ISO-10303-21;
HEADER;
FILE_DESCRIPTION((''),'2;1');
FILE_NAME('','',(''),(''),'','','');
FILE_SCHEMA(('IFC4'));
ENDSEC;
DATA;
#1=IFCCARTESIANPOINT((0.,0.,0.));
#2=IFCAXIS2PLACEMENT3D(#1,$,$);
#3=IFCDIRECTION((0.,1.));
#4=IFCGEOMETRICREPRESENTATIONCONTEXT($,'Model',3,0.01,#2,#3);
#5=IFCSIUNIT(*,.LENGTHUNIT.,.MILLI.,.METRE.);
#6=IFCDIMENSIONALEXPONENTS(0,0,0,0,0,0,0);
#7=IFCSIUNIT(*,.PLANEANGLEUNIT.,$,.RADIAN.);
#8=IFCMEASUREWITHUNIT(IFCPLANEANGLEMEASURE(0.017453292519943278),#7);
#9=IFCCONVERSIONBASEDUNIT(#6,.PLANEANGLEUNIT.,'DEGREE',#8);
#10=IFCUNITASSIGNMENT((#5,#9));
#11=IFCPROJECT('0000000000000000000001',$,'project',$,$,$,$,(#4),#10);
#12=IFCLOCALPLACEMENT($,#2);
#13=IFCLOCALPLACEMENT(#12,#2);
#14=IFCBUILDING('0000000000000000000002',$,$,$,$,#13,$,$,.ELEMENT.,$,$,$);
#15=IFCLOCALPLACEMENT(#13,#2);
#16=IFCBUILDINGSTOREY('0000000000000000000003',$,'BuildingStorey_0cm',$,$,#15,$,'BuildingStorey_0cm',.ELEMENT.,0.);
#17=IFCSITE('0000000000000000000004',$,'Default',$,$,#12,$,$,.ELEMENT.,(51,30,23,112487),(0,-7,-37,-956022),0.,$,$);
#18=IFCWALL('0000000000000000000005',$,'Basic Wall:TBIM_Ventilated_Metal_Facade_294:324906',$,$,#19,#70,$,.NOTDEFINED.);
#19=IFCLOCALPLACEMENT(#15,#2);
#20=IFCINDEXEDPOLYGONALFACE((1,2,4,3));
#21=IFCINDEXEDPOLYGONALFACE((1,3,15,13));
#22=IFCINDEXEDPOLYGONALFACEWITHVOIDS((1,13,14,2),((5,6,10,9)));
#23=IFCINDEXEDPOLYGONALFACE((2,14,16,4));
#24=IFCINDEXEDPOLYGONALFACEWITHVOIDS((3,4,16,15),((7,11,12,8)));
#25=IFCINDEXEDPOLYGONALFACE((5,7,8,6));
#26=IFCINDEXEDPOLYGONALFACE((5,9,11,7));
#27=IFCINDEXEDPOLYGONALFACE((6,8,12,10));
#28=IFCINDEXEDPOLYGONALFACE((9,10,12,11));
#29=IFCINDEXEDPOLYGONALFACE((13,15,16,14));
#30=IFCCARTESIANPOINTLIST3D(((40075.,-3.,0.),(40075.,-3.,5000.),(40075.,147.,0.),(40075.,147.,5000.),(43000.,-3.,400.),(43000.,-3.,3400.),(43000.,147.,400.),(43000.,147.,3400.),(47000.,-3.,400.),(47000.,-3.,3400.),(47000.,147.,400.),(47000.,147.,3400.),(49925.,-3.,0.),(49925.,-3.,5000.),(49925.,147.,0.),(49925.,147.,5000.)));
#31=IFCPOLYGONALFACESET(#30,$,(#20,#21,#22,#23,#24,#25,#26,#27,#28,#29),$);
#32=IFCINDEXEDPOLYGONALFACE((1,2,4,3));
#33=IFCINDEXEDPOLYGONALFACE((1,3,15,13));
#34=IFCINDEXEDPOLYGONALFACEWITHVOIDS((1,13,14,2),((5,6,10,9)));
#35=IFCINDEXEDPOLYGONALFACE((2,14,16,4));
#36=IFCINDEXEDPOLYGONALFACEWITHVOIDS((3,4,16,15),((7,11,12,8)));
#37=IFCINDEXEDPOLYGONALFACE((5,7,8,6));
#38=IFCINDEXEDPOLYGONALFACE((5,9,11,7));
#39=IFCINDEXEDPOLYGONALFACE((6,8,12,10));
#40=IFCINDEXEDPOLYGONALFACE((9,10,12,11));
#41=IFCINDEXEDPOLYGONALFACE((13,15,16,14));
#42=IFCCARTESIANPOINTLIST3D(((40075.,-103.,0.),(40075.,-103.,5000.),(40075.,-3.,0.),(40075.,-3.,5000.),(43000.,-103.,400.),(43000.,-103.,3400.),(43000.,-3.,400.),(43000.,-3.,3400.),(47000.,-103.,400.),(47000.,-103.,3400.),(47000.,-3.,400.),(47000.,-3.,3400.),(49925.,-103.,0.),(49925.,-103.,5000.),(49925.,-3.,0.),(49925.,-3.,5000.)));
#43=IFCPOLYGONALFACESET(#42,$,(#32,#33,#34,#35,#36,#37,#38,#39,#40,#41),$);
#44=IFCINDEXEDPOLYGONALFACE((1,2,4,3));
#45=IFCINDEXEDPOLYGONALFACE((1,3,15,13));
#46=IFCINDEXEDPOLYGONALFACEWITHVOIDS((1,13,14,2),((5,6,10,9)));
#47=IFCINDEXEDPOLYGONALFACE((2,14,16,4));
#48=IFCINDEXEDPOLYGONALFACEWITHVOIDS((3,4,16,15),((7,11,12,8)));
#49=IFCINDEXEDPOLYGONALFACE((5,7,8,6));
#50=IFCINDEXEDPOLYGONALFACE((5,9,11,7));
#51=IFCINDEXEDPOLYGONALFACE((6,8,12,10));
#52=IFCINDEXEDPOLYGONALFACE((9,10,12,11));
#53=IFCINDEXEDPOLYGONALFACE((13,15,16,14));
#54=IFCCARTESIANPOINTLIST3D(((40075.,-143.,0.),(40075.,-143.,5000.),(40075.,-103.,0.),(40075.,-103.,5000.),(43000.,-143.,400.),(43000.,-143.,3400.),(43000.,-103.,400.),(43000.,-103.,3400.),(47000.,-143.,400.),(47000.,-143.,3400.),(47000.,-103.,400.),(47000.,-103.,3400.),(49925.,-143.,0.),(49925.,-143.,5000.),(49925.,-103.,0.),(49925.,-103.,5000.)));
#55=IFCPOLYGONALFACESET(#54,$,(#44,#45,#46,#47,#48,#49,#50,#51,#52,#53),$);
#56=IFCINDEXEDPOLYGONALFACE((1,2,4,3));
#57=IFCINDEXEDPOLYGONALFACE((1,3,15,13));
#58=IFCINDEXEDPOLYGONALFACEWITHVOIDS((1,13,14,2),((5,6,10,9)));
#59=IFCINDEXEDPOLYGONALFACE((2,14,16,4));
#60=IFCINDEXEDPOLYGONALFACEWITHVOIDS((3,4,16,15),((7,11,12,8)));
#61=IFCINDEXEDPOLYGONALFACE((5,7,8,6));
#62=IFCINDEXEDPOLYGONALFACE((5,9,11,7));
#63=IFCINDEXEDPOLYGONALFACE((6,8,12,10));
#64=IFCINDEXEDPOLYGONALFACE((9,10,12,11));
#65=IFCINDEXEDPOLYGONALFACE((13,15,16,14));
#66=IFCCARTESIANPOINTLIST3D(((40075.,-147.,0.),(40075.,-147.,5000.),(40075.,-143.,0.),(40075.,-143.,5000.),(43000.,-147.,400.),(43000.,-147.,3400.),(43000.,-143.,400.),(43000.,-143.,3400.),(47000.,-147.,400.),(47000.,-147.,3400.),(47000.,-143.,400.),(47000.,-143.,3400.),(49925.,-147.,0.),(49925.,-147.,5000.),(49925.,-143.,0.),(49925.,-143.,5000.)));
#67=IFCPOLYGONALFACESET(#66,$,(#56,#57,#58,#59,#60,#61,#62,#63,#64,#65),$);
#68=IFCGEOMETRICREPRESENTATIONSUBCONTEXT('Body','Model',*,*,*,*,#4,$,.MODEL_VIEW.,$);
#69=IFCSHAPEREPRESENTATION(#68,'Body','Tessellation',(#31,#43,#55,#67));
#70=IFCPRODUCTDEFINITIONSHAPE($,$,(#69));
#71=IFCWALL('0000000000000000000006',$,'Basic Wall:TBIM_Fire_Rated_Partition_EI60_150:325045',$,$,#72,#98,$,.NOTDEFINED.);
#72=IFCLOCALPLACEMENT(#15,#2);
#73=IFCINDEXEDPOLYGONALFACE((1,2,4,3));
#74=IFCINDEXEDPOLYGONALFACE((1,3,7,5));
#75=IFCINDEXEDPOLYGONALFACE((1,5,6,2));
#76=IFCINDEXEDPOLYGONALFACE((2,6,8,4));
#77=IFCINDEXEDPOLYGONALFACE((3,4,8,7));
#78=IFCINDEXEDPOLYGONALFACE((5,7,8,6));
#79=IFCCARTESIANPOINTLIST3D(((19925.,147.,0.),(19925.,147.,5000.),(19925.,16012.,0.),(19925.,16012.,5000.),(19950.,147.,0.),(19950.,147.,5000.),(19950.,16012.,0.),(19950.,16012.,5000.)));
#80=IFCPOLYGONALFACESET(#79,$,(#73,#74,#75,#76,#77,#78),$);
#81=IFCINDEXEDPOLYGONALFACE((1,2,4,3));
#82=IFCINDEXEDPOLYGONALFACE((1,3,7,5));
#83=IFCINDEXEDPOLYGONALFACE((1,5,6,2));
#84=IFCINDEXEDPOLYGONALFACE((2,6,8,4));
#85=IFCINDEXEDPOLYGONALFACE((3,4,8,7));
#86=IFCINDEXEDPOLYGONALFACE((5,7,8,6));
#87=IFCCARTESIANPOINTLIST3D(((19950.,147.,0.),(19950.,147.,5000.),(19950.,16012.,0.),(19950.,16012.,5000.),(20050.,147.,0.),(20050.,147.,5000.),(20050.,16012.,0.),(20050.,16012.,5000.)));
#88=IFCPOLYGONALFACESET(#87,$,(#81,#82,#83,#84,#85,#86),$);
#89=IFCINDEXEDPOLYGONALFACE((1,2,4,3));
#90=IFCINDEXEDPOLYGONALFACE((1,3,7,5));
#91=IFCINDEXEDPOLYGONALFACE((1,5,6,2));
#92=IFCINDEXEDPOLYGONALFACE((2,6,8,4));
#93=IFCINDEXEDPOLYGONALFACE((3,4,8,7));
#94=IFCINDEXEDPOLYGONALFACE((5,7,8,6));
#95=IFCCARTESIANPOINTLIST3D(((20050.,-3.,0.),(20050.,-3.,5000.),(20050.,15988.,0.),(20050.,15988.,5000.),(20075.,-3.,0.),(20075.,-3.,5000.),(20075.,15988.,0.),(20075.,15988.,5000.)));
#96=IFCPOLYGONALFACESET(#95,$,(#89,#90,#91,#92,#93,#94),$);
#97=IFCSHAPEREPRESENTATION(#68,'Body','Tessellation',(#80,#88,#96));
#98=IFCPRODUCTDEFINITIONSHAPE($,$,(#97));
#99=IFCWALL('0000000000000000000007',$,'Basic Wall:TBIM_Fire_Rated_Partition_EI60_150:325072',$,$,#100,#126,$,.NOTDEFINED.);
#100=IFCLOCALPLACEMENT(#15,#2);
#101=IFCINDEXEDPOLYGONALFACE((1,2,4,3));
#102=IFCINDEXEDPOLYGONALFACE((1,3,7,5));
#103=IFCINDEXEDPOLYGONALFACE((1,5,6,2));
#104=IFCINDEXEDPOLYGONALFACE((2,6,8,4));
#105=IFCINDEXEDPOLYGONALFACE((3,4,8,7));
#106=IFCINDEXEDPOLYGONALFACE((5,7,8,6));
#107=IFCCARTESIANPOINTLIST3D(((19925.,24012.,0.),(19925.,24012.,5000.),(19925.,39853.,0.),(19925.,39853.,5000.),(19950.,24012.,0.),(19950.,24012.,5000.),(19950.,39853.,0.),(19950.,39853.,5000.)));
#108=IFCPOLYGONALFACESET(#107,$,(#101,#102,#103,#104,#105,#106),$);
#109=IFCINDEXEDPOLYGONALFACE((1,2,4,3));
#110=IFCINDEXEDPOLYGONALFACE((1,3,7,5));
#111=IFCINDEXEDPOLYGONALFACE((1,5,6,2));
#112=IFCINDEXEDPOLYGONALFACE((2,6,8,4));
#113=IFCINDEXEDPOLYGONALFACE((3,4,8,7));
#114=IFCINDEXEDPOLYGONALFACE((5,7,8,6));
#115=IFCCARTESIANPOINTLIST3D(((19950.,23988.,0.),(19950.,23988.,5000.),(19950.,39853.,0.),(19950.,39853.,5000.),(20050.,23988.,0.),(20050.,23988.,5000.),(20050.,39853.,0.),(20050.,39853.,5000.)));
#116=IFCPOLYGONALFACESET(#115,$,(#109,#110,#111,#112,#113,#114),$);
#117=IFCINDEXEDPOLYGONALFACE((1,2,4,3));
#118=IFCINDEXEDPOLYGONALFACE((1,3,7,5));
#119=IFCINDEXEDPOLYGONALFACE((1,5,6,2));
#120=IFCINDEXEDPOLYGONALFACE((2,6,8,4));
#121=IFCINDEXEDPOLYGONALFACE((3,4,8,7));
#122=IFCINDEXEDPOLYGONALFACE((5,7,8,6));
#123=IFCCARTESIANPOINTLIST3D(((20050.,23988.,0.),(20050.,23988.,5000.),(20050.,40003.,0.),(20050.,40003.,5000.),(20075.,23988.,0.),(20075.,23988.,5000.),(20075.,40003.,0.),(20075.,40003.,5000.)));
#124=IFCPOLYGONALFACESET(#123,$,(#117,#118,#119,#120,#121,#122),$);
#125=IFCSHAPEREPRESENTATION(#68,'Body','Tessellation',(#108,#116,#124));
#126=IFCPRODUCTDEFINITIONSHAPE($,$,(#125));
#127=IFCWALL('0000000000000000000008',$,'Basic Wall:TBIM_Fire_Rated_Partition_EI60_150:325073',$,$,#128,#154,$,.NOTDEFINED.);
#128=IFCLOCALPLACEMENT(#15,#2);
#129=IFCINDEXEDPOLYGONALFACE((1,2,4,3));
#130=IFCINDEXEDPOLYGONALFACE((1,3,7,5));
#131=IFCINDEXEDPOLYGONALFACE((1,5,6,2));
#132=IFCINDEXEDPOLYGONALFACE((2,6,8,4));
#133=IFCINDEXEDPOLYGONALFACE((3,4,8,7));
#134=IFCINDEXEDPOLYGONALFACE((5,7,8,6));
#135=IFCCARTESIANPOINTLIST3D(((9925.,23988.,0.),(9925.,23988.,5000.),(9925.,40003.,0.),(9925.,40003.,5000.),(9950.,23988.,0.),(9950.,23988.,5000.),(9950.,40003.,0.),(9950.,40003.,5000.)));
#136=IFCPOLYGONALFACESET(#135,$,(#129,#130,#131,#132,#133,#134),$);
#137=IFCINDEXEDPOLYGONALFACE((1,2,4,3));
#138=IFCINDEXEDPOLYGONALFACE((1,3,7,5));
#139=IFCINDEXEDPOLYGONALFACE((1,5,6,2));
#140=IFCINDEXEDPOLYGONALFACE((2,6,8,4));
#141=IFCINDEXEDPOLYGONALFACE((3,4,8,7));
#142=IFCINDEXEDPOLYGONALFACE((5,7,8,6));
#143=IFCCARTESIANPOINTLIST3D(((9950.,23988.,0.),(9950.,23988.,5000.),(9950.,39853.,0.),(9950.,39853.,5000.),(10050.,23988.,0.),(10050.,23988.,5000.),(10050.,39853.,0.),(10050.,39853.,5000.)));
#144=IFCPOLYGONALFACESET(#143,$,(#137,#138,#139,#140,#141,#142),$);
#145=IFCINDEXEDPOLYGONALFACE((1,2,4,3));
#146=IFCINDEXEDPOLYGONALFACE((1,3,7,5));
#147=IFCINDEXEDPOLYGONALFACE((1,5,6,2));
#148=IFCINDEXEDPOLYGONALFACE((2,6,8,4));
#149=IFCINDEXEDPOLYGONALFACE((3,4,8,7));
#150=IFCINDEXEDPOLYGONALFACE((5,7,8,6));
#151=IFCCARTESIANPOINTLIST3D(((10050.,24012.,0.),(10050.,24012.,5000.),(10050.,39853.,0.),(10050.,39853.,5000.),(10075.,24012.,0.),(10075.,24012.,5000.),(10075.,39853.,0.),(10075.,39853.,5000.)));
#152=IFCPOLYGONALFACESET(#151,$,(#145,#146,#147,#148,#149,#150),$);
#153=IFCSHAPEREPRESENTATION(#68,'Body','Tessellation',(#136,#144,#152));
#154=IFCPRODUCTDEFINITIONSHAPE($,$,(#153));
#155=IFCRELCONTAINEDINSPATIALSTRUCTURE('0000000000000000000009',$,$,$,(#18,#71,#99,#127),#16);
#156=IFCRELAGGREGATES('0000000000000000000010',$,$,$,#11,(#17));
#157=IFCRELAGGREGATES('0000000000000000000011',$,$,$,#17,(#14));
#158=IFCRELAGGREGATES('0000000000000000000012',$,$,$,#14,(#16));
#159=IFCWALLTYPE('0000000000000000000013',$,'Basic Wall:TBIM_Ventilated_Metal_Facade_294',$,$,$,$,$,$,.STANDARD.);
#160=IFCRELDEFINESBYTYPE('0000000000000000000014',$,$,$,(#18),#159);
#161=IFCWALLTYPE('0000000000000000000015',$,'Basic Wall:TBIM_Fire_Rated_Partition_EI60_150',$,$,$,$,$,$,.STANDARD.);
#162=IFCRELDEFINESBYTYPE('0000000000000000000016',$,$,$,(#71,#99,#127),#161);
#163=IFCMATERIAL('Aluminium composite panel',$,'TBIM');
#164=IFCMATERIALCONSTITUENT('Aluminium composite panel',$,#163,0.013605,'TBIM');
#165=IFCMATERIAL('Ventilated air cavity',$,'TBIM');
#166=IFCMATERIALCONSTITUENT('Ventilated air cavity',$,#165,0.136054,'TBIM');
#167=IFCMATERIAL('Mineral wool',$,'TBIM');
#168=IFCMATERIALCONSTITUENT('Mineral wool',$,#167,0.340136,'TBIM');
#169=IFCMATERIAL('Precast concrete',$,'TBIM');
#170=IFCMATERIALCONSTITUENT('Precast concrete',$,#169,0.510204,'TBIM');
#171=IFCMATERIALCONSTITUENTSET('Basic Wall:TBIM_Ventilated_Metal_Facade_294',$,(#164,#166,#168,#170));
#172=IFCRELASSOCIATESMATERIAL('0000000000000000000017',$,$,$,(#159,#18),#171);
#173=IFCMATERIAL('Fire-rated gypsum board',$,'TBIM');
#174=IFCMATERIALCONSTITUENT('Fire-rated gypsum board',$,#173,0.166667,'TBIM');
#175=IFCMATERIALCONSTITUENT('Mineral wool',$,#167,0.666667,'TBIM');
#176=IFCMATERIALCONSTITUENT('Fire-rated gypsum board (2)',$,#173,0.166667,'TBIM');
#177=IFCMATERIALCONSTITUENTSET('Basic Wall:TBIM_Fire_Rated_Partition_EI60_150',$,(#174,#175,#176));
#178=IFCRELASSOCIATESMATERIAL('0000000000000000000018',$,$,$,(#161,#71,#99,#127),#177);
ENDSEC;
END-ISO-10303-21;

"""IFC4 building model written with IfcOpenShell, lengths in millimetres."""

from ifc_helpers import new_model, entity, si_unit, converted_unit, direction, frame, origin, place, context, subcontext, project, spatial, indexed_curve, outline, extrude, material, constituent, constituent_set, type_object, element, save


model = new_model("IFC4")

# Units and contexts
model_context = context("Model", 3, precision=0.01, world=origin(), true_north=direction((0.0, 1.0)))
body_context = subcontext(model_context, "Body", "Model", "MODEL_VIEW")
ifc_project = project(units=[si_unit("LENGTHUNIT", "METRE", prefix="MILLI"), converted_unit("PLANEANGLEUNIT", "DEGREE", entity("IfcPlaneAngleMeasure", 0.017453292519943278), si_unit("PLANEANGLEUNIT", "RADIAN"), dimensions=[0, 0, 0, 0, 0, 0, 0])], contexts=[model_context])

# Site, building, storey
site_placement = place(None, origin())
site = spatial("IfcSite", under=ifc_project, at=site_placement, Name="Default", CompositionType="ELEMENT", RefLatitude=(51, 30, 23, 112487), RefLongitude=(0, -7, -37, -956022), RefElevation=0.0)
building_placement = place(site_placement, origin())
building = spatial("IfcBuilding", under=site, at=building_placement, CompositionType="ELEMENT")
storey_placement = place(building_placement, origin())
storey = spatial("IfcBuildingStorey", under=building, at=storey_placement, Name="BuildingStorey_0cm", LongName="BuildingStorey_0cm", CompositionType="ELEMENT", Elevation=0.0)

# Wall, opening
ifc_material_1 = material(Name="Aluminium composite panel", Category="TBIM")
ifc_constituent_1 = constituent(ifc_material_1, Name="Aluminium composite panel", Category="TBIM", fraction=0.013605)
ifc_material_2 = material(Name="Ventilated air cavity", Category="TBIM")
ifc_constituent_2 = constituent(ifc_material_2, Name="Ventilated air cavity", Category="TBIM", fraction=0.136054)
ifc_material_3 = material(Name="Mineral wool", Category="TBIM")
ifc_constituent_3 = constituent(ifc_material_3, Name="Mineral wool", Category="TBIM", fraction=0.340136)
ifc_material_4 = material(Name="Precast concrete", Category="TBIM")
ifc_constituent_4 = constituent(ifc_material_4, Name="Precast concrete", Category="TBIM", fraction=0.510204)
ifc_constituent_set_1 = constituent_set(constituents=[ifc_constituent_1, ifc_constituent_2, ifc_constituent_3, ifc_constituent_4], Name="Basic Wall:TBIM_Ventilated_Metal_Facade_294")
wall_type_1 = type_object("IfcWallType", Name="Basic Wall:TBIM_Ventilated_Metal_Facade_294", PredefinedType="STANDARD", material=ifc_constituent_set_1)
wall_1_placement = place(storey_placement, frame((40075.0, 0.0, 0.0)))
wall_1 = element("IfcWall", 1, at=wall_1_placement, inside=storey, type_object=wall_type_1, material=ifc_constituent_set_1, Name="Basic Wall:TBIM_Ventilated_Metal_Facade_294:324906", PredefinedType="NOTDEFINED", context=body_context, shape_type="SweptSolid", body=[
    extrude(outline(indexed_curve([(-2500.0, -4925.0), (2500.0, -4925.0), (2500.0, 4925.0), (-2500.0, 4925.0), (-2500.0, -4925.0)], self_intersect=False), holes=[indexed_curve([(-2100.0, -2000.0), (-2100.0, 2000.0), (900.0, 2000.0), (900.0, -2000.0), (-2100.0, -2000.0)], self_intersect=False)]), frame((4925.0, -3.0, 2500.0), z_axis=(0.0, 1.0, 0.0), x_axis=(0.0, 0.0, 1.0)), (0.0, 0.0, 1.0), 150.0),
    extrude(outline(indexed_curve([(-2500.0, -4925.0), (2500.0, -4925.0), (2500.0, 4925.0), (-2500.0, 4925.0), (-2500.0, -4925.0)], self_intersect=False), holes=[indexed_curve([(-2100.0, -2000.0), (-2100.0, 2000.0), (900.0, 2000.0), (900.0, -2000.0), (-2100.0, -2000.0)], self_intersect=False)]), frame((4925.0, -103.0, 2500.0), z_axis=(0.0, 1.0, 0.0), x_axis=(0.0, 0.0, 1.0)), (0.0, 0.0, 1.0), 100.0),
    extrude(outline(indexed_curve([(-2500.0, -4925.0), (2500.0, -4925.0), (2500.0, 4925.0), (-2500.0, 4925.0), (-2500.0, -4925.0)], self_intersect=False), holes=[indexed_curve([(-2100.0, -2000.0), (-2100.0, 2000.0), (900.0, 2000.0), (900.0, -2000.0), (-2100.0, -2000.0)], self_intersect=False)]), frame((4925.0, -143.0, 2500.0), z_axis=(0.0, 1.0, 0.0), x_axis=(0.0, 0.0, 1.0)), (0.0, 0.0, 1.0), 40.0),
    extrude(outline(indexed_curve([(-2500.0, -4925.0), (2500.0, -4925.0), (2500.0, 4925.0), (-2500.0, 4925.0), (-2500.0, -4925.0)], self_intersect=False), holes=[indexed_curve([(900.0, -2000.0), (-2100.0, -2000.0), (-2100.0, 2000.0), (900.0, 2000.0), (900.0, -2000.0)], self_intersect=False)]), frame((4925.0, -147.0, 2500.0), z_axis=(0.0, 1.0, 0.0), x_axis=(0.0, 0.0, 1.0)), (0.0, 0.0, 1.0), 4.0),
])
opening_1_placement = place(wall_1_placement, frame((2925.0, -147.0, 400.0)))
element("IfcOpeningElement", 2, at=opening_1_placement, cuts=wall_1, PredefinedType="OPENING", context=body_context, shape_type="SweptSolid", body=[
    extrude(outline(indexed_curve([(3000.0, 0.0), (3000.0, 4000.0), (0.0, 4000.0), (0.0, 0.0), (3000.0, 0.0)], self_intersect=False)), frame((0.0, 0.0, 0.0), z_axis=(0.0, 1.0, 0.0), x_axis=(0.0, 0.0, 1.0)), (0.0, 0.0, 1.0), 294.0),
])

# Walls
ifc_material_5 = material(Name="Fire-rated gypsum board", Category="TBIM")
ifc_constituent_5 = constituent(ifc_material_5, Name="Fire-rated gypsum board", Category="TBIM", fraction=0.166667)
ifc_constituent_6 = constituent(ifc_material_3, Name="Mineral wool", Category="TBIM", fraction=0.666667)
ifc_constituent_7 = constituent(ifc_material_5, Name="Fire-rated gypsum board (2)", Category="TBIM", fraction=0.166667)
ifc_constituent_set_2 = constituent_set(constituents=[ifc_constituent_5, ifc_constituent_6, ifc_constituent_7], Name="Basic Wall:TBIM_Fire_Rated_Partition_EI60_150")
wall_type_2 = type_object("IfcWallType", Name="Basic Wall:TBIM_Fire_Rated_Partition_EI60_150", PredefinedType="STANDARD", material=ifc_constituent_set_2)
wall_2_placement = place(storey_placement, frame((20000.0, 147.0, 0.0), z_axis=(0.0, 0.0, 1.0), x_axis=(0.0, 1.0, 0.0)))
element("IfcWall", 3, at=wall_2_placement, inside=storey, type_object=wall_type_2, material=ifc_constituent_set_2, Name="Basic Wall:TBIM_Fire_Rated_Partition_EI60_150:325045", PredefinedType="NOTDEFINED", context=body_context, shape_type="SweptSolid", body=[
    extrude(outline(indexed_curve([(-12.5, -7932.5), (12.5, -7932.5), (12.5, 7932.5), (-12.5, 7932.5), (-12.5, -7932.5)], self_intersect=False)), frame((7932.5, 62.5, 0.0), z_axis=(0.0, 0.0, 1.0), x_axis=(0.0, -1.0, 0.0)), (0.0, 0.0, 1.0), 5000.0),
    extrude(outline(indexed_curve([(-7932.5, -50.0), (7932.5, -50.0), (7932.5, 50.0), (-7932.5, 50.0), (-7932.5, -50.0)], self_intersect=False)), frame((7932.5, 0.0, 0.0)), (0.0, 0.0, 1.0), 5000.0),
    extrude(outline(indexed_curve([(-12.5, -7995.5), (12.5, -7995.5), (12.5, 7995.5), (-12.5, 7995.5), (-12.5, -7995.5)], self_intersect=False)), frame((7845.5, -62.5, 0.0), z_axis=(0.0, 0.0, 1.0), x_axis=(0.0, 1.0, 0.0)), (0.0, 0.0, 1.0), 5000.0),
])
wall_3_placement = place(storey_placement, frame((20000.0, 24012.0, 0.0), z_axis=(0.0, 0.0, 1.0), x_axis=(0.0, 1.0, 0.0)))
element("IfcWall", 4, at=wall_3_placement, inside=storey, type_object=wall_type_2, material=ifc_constituent_set_2, Name="Basic Wall:TBIM_Fire_Rated_Partition_EI60_150:325072", PredefinedType="NOTDEFINED", context=body_context, shape_type="SweptSolid", body=[
    extrude(outline(indexed_curve([(-12.5, -7920.5), (12.5, -7920.5), (12.5, 7920.5), (-12.5, 7920.5), (-12.5, -7920.5)], self_intersect=False)), frame((7920.5, 62.5, 0.0), z_axis=(0.0, 0.0, 1.0), x_axis=(0.0, -1.0, 0.0)), (0.0, 0.0, 1.0), 5000.0),
    extrude(outline(indexed_curve([(-7932.5, -50.0), (7932.5, -50.0), (7932.5, 50.0), (-7932.5, 50.0), (-7932.5, -50.0)], self_intersect=False)), frame((7908.5, 0.0, 0.0)), (0.0, 0.0, 1.0), 5000.0),
    extrude(outline(indexed_curve([(-12.5, -8007.5), (12.5, -8007.5), (12.5, 8007.5), (-12.5, 8007.5), (-12.5, -8007.5)], self_intersect=False)), frame((7983.5, -62.5, 0.0), z_axis=(0.0, 0.0, 1.0), x_axis=(0.0, 1.0, 0.0)), (0.0, 0.0, 1.0), 5000.0),
])
wall_4_placement = place(storey_placement, frame((10000.0, 24012.0, 0.0), z_axis=(0.0, 0.0, 1.0), x_axis=(0.0, 1.0, 0.0)))
element("IfcWall", 5, at=wall_4_placement, inside=storey, type_object=wall_type_2, material=ifc_constituent_set_2, Name="Basic Wall:TBIM_Fire_Rated_Partition_EI60_150:325073", PredefinedType="NOTDEFINED", context=body_context, shape_type="SweptSolid", body=[
    extrude(outline(indexed_curve([(-12.5, -8007.5), (12.5, -8007.5), (12.5, 8007.5), (-12.5, 8007.5), (-12.5, -8007.5)], self_intersect=False)), frame((7983.5, 62.5, 0.0), z_axis=(0.0, 0.0, 1.0), x_axis=(0.0, -1.0, 0.0)), (0.0, 0.0, 1.0), 5000.0),
    extrude(outline(indexed_curve([(-7932.5, -50.0), (7932.5, -50.0), (7932.5, 50.0), (-7932.5, 50.0), (-7932.5, -50.0)], self_intersect=False)), frame((7908.5, 0.0, 0.0)), (0.0, 0.0, 1.0), 5000.0),
    extrude(outline(indexed_curve([(-12.5, -7920.5), (12.5, -7920.5), (12.5, 7920.5), (-12.5, 7920.5), (-12.5, -7920.5)], self_intersect=False)), frame((7920.5, -62.5, 0.0), z_axis=(0.0, 0.0, 1.0), x_axis=(0.0, 1.0, 0.0)), (0.0, 0.0, 1.0), 5000.0),
])

save(model, "model.ifc")
